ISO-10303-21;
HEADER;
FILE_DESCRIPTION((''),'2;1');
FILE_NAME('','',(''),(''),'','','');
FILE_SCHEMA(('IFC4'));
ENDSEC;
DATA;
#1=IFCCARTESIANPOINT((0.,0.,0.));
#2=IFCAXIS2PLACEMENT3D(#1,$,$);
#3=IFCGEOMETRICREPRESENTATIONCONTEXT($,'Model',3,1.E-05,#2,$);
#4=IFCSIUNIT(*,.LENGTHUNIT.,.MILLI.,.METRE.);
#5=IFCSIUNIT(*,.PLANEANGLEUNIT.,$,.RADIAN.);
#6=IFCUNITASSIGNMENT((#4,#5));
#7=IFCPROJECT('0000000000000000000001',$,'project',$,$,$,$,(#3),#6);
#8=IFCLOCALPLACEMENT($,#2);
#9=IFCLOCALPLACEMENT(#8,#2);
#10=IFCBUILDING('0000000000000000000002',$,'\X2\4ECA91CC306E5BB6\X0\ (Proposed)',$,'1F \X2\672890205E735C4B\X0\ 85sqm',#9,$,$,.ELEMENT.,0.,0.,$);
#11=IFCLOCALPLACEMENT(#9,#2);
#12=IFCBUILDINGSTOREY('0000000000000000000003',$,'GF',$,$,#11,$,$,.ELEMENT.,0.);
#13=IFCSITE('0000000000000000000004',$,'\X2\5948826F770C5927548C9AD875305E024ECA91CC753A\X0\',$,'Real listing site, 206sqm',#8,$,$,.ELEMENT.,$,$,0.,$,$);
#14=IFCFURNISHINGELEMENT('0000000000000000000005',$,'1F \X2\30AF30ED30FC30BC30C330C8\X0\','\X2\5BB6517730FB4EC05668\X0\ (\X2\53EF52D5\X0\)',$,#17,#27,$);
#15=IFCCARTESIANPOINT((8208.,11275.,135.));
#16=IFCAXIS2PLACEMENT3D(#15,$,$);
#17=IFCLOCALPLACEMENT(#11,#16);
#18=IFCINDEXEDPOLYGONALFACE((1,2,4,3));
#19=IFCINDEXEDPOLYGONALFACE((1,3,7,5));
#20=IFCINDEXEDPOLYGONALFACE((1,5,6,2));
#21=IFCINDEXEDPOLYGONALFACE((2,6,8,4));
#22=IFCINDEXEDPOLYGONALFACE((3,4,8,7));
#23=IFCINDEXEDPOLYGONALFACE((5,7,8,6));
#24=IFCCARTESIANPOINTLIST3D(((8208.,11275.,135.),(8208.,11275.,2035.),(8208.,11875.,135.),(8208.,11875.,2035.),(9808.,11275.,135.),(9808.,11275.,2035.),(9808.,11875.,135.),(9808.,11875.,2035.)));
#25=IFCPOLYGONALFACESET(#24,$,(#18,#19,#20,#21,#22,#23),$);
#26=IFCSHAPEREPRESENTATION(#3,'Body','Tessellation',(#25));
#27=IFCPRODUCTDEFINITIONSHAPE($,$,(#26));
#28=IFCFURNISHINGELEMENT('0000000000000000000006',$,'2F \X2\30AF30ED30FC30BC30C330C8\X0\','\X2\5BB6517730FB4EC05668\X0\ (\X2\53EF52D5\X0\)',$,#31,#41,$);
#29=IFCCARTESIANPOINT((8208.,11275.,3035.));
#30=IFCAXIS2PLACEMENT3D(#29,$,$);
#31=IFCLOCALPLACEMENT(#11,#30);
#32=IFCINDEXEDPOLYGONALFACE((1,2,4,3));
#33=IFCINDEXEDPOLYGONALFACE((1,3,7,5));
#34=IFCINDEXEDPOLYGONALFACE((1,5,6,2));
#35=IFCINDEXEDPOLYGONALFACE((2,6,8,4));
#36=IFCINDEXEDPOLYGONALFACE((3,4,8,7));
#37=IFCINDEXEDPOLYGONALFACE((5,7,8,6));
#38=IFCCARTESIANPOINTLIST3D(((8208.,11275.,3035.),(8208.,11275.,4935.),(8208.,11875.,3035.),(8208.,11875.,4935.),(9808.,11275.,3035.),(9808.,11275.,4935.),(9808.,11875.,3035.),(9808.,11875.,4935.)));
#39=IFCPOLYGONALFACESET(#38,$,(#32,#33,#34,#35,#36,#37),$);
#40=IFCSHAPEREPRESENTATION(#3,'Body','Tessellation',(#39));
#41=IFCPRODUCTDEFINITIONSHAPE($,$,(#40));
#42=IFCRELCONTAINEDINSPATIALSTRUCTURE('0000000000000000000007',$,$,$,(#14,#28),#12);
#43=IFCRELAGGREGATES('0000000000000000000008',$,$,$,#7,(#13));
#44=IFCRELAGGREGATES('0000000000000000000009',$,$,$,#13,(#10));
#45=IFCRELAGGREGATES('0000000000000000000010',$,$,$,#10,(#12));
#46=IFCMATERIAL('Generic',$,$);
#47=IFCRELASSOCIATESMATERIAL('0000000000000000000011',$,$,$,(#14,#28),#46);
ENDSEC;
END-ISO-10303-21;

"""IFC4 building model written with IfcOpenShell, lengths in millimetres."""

from ifc_helpers import new_model, si_unit, frame, frame_2d, origin, place, context, project, spatial, rectangle, extrude, material, element, save


model = new_model("IFC4")

# Units and contexts
model_context = context("Model", 3, precision=1e-05, world=origin())
ifc_project = project(units=[si_unit("LENGTHUNIT", "METRE", prefix="MILLI"), si_unit("PLANEANGLEUNIT", "RADIAN")], contexts=[model_context])

# Site, building, storey
site_placement = place(None, origin())
site = spatial("IfcSite", under=ifc_project, at=site_placement, Name="奈良県大和高田市今里町", ObjectType="Real listing site, 206sqm", CompositionType="ELEMENT", RefElevation=0.0)
building_placement = place(site_placement, origin())
building = spatial("IfcBuilding", under=site, at=building_placement, Name="今里の家 (Proposed)", ObjectType="1F 木造平屋 85sqm", CompositionType="ELEMENT", ElevationOfRefHeight=0.0, ElevationOfTerrain=0.0)
storey_placement = place(building_placement, origin())
storey = spatial("IfcBuildingStorey", under=building, at=storey_placement, Name="GF", CompositionType="ELEMENT", Elevation=0.0)

# Shared definitions
ifc_material_1 = material(Name="Generic")

# Furnishing elements
furnishing_1_placement = place(storey_placement, frame((8208.0, 11275.0, 135.0)))
element("IfcFurnishingElement", 1, at=furnishing_1_placement, inside=storey, material=ifc_material_1, Name="1F クローゼット", Description="家具・什器 (可動)", context=model_context, shape_type="SweptSolid", body=[
    extrude(rectangle(XDim=1600.0, YDim=600.0, at=frame_2d((800.0, 300.0))), frame((8208.0, 11275.0, 135.0)), (0.0, 0.0, 1.0), 1900.0),
])
furnishing_2_placement = place(storey_placement, frame((8208.0, 11275.0, 3035.0)))
element("IfcFurnishingElement", 2, at=furnishing_2_placement, inside=storey, material=ifc_material_1, Name="2F クローゼット", Description="家具・什器 (可動)", context=model_context, shape_type="SweptSolid", body=[
    extrude(rectangle(XDim=1600.0, YDim=600.0, at=frame_2d((800.0, 300.0))), frame((8208.0, 11275.0, 3035.0)), (0.0, 0.0, 1.0), 1900.0),
])

save(model, "model.ifc")
